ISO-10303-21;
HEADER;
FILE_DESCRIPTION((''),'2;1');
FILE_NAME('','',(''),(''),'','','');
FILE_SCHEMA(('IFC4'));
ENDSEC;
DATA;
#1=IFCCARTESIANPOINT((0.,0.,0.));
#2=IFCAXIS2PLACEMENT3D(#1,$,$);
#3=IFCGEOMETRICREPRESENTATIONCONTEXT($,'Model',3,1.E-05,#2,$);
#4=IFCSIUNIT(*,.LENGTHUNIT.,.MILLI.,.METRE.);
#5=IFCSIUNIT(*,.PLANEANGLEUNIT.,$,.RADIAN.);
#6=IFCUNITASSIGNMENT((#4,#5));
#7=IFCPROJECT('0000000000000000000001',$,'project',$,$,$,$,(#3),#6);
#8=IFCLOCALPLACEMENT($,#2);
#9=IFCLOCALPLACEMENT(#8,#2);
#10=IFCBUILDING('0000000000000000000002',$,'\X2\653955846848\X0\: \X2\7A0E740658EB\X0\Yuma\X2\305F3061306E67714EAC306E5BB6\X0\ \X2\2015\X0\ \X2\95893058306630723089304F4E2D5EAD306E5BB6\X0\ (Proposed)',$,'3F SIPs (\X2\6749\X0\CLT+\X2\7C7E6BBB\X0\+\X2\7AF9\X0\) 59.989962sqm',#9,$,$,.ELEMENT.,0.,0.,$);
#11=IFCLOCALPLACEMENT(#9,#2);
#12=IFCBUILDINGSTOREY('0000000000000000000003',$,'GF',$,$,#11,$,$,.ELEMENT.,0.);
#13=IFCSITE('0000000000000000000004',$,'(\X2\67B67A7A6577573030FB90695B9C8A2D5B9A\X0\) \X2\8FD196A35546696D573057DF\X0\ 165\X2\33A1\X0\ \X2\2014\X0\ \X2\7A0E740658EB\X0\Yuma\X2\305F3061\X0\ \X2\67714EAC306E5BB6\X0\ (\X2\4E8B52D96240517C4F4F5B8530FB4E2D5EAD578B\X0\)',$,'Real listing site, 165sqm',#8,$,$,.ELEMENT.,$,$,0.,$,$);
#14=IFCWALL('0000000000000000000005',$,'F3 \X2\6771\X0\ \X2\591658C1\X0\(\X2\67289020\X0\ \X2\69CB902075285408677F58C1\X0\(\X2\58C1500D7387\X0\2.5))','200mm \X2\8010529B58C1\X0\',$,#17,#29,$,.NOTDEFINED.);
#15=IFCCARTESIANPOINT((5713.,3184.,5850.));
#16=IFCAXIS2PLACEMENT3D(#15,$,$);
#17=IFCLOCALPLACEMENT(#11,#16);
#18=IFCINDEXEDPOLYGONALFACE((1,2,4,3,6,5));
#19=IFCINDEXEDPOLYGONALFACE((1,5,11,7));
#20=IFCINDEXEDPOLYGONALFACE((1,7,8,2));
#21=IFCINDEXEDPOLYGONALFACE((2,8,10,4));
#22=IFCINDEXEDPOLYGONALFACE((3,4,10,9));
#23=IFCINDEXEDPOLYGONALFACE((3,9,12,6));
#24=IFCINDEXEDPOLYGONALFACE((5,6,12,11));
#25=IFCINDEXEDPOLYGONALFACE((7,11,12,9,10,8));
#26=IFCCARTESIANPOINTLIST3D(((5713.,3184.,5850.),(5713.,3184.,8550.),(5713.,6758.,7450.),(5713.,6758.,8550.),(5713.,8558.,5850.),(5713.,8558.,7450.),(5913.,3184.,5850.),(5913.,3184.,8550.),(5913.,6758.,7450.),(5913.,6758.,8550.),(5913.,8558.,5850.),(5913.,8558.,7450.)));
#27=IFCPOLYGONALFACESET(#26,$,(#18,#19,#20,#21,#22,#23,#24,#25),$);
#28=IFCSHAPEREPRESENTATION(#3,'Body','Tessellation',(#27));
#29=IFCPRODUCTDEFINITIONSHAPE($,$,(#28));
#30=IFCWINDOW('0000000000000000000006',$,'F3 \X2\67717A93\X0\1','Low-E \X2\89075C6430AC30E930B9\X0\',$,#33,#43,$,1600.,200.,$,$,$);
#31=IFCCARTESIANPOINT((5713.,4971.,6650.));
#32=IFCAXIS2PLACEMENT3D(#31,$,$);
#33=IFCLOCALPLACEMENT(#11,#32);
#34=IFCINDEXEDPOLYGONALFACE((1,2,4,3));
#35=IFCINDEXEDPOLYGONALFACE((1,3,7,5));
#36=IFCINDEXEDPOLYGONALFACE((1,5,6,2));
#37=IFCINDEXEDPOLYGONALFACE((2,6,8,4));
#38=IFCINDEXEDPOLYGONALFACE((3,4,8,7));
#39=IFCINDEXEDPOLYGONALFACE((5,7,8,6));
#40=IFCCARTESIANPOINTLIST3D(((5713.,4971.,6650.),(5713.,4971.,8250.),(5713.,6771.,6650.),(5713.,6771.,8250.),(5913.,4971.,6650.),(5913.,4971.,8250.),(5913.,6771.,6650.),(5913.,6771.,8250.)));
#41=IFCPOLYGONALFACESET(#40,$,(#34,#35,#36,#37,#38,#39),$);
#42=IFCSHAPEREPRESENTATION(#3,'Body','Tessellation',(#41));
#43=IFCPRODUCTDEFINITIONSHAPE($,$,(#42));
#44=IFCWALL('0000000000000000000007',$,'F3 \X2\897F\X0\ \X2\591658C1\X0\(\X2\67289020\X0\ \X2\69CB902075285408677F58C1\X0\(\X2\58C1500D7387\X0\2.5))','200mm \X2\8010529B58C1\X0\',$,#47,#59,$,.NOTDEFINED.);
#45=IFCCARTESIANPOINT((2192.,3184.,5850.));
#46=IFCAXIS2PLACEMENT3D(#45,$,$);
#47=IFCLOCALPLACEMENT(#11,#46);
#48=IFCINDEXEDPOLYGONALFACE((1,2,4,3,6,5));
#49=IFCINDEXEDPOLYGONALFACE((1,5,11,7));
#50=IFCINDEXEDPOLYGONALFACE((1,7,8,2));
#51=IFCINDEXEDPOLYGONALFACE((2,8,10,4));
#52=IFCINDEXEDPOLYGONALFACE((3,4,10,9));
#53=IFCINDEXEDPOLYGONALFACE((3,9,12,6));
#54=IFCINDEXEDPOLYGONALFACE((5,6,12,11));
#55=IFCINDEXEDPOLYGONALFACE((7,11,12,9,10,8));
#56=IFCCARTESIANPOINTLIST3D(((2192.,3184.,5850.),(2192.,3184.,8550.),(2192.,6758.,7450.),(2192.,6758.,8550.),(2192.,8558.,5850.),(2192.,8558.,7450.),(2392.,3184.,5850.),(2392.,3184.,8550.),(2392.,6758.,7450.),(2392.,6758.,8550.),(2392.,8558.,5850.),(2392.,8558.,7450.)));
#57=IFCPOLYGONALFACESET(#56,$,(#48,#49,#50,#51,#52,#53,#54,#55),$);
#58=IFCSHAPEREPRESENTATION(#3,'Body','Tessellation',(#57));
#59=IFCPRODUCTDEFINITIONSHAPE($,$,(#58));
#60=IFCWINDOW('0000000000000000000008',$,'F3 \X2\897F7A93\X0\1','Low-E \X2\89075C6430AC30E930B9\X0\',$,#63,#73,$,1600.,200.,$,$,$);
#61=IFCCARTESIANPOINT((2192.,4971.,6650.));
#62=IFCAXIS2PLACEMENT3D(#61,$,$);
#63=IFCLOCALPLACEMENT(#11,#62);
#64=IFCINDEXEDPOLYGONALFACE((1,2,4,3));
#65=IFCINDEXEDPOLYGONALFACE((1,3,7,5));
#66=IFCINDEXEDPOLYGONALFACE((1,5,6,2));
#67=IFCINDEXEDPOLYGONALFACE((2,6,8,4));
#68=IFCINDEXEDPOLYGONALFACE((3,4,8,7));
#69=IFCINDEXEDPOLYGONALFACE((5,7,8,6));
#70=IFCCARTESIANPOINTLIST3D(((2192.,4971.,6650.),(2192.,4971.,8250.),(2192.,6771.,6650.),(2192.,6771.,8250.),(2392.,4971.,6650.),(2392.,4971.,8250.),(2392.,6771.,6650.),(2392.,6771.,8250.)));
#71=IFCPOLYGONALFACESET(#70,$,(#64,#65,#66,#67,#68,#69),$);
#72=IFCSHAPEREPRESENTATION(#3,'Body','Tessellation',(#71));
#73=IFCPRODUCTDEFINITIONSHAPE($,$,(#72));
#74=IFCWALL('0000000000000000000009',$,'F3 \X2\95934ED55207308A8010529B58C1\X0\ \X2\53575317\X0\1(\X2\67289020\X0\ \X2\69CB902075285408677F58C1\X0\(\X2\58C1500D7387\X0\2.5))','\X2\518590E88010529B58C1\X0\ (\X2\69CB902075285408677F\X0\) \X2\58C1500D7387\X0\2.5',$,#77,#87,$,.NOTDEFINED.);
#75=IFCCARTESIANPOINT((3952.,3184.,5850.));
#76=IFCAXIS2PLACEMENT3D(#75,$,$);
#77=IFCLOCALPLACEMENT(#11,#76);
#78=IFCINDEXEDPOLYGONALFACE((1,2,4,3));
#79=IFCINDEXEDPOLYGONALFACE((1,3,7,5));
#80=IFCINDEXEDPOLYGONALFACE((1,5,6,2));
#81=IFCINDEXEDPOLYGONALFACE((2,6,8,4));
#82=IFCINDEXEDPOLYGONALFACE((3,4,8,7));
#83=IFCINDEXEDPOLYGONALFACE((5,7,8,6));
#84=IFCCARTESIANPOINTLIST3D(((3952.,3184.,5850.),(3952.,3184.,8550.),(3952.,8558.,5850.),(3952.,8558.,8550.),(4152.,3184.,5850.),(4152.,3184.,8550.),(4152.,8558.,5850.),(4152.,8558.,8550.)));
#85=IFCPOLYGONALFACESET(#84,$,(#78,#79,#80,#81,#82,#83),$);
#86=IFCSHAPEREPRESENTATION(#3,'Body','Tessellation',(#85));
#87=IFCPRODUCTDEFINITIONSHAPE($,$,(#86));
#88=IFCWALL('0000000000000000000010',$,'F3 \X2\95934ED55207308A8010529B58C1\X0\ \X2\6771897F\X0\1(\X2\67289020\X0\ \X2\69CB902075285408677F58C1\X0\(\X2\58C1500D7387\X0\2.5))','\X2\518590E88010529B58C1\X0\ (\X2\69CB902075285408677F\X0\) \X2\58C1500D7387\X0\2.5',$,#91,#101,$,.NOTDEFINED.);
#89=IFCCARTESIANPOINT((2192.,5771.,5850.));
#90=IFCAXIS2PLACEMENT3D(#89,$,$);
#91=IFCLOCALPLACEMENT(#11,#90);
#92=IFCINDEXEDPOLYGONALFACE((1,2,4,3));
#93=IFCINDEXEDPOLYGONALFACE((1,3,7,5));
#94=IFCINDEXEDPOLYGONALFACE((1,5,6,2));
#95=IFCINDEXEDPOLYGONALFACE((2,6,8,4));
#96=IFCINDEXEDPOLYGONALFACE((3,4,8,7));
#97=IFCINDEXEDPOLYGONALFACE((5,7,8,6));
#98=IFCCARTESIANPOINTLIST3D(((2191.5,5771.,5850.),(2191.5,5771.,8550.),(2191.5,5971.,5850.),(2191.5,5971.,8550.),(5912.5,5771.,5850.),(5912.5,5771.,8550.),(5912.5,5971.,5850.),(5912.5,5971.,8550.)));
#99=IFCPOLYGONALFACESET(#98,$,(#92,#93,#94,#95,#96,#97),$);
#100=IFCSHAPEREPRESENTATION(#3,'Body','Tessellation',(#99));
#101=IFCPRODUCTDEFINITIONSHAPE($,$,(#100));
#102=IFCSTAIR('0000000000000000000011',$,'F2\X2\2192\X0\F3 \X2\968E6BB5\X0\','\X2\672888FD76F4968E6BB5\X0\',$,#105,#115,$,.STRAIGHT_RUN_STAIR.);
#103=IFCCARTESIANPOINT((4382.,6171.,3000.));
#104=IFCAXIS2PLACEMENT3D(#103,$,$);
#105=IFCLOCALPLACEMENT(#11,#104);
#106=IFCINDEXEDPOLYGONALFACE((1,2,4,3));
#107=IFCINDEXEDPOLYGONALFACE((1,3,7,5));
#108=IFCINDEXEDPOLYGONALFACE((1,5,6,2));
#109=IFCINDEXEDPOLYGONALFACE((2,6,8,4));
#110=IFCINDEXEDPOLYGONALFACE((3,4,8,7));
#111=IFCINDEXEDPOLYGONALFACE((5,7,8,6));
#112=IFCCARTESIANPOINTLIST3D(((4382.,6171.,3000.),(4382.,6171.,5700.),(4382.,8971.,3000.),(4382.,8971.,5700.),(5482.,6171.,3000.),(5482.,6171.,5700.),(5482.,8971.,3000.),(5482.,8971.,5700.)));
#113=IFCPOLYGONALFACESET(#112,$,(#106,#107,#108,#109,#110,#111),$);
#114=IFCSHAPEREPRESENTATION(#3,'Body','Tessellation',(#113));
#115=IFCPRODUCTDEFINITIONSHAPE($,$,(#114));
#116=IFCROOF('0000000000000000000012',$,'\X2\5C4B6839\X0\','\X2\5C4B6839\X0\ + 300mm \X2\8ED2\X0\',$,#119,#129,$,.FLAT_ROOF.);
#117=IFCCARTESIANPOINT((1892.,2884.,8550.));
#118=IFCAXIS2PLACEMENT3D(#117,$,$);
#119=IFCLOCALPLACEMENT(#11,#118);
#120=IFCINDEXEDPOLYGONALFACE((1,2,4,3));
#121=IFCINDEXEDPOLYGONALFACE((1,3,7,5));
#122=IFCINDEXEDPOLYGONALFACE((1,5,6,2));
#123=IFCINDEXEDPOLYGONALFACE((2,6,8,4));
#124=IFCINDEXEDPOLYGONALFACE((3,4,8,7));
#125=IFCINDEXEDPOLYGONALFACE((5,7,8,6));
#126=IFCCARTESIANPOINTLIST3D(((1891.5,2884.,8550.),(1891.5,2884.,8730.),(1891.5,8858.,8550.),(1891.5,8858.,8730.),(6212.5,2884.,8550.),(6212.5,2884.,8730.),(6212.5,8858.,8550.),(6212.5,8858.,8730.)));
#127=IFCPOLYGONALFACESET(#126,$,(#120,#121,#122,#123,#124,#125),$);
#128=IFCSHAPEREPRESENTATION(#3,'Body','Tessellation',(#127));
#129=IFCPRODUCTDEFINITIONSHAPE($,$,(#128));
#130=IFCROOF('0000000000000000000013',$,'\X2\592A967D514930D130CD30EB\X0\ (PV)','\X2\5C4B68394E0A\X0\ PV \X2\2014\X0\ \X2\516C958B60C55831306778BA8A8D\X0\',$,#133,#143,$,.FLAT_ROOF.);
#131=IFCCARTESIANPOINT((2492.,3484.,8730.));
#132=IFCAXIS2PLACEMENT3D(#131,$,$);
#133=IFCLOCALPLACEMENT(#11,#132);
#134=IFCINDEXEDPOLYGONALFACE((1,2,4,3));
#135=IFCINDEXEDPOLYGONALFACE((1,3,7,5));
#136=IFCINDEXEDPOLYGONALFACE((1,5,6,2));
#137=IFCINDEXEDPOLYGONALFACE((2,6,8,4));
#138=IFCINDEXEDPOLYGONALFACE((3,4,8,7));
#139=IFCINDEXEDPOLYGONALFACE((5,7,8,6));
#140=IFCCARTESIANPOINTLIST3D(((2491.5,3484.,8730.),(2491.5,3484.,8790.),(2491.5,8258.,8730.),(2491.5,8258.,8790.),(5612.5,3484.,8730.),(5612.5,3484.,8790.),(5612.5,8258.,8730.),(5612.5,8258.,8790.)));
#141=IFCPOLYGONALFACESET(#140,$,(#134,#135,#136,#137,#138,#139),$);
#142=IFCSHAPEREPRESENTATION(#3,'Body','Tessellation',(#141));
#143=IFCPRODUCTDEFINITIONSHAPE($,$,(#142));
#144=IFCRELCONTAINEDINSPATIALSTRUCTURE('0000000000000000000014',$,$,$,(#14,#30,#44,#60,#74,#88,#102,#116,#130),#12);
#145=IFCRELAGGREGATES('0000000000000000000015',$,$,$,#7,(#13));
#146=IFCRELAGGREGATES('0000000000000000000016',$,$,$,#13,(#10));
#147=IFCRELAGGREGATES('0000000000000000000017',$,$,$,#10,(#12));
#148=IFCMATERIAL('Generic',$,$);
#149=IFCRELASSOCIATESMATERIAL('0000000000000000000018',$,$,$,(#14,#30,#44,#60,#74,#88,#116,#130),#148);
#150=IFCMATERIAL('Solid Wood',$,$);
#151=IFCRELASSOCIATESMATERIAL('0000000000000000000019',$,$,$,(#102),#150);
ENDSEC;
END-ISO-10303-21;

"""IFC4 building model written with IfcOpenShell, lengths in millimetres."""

from ifc_helpers import new_model, si_unit, frame, frame_2d, origin, place, context, project, spatial, rectangle, extrude, material, element, fill, save


model = new_model("IFC4")

# Units and contexts
model_context = context("Model", 3, precision=1e-05, world=origin())
ifc_project = project(units=[si_unit("LENGTHUNIT", "METRE", prefix="MILLI"), si_unit("PLANEANGLEUNIT", "RADIAN")], contexts=[model_context])

# Site, building, storey
site_placement = place(None, origin())
site = spatial("IfcSite", under=ifc_project, at=site_placement, Name="(架空敷地・適宜設定) 近隣商業地域 165㎡ — 税理士Yumaたち 東京の家 (事務所兼住宅・中庭型)", ObjectType="Real listing site, 165sqm", CompositionType="ELEMENT", RefElevation=0.0)
building_placement = place(site_placement, origin())
building = spatial("IfcBuilding", under=site, at=building_placement, Name="改善案: 税理士Yumaたちの東京の家 ― 閉じてひらく中庭の家 (Proposed)", ObjectType="3F SIPs (杉CLT+籾殻+竹) 59.989962sqm", CompositionType="ELEMENT", ElevationOfRefHeight=0.0, ElevationOfTerrain=0.0)
storey_placement = place(building_placement, origin())
storey = spatial("IfcBuildingStorey", under=building, at=storey_placement, Name="GF", CompositionType="ELEMENT", Elevation=0.0)

# Shared definitions
ifc_material_1 = material(Name="Generic")

# Walls, openings, windows
wall_1_placement = place(storey_placement, frame((5713.0, 3184.0, 5850.0)))
wall_1 = element("IfcWall", 1, at=wall_1_placement, inside=storey, material=ifc_material_1, Name="F3 東 外壁(木造 構造用合板壁(壁倍率2.5))", Description="200mm 耐力壁", PredefinedType="NOTDEFINED", context=model_context, shape_type="SweptSolid", body=[
    extrude(rectangle(XDim=200.0, YDim=5374.0, at=frame_2d((100.0, 2687.0))), frame((5713.0, 3184.0, 5850.0)), (0.0, 0.0, 1.0), 2700.0),
])
opening_1_placement = place(storey_placement, frame((5713.0, 4971.0, 6650.0)))
opening_1 = element("IfcOpeningElement", 2, at=opening_1_placement, cuts=wall_1, PredefinedType="NOTDEFINED", context=model_context, shape_type="SweptSolid", body=[
    extrude(rectangle(XDim=200.0, YDim=1800.0, at=frame_2d((100.0, 900.0))), frame((5713.0, 4971.0, 6650.0)), (0.0, 0.0, 1.0), 1600.0),
])
window_1_placement = place(storey_placement, frame((5713.0, 4971.0, 6650.0)))
window_1 = element("IfcWindow", 3, at=window_1_placement, inside=storey, material=ifc_material_1, Name="F3 東窓1", Description="Low-E 複層ガラス", OverallHeight=1600.0, OverallWidth=200.0, context=model_context, shape_type="SweptSolid", body=[
    extrude(rectangle(XDim=200.0, YDim=1800.0, at=frame_2d((100.0, 900.0))), frame((5713.0, 4971.0, 6650.0)), (0.0, 0.0, 1.0), 1600.0),
])
fill(opening_1, window_1)
wall_2_placement = place(storey_placement, frame((2192.0, 3184.0, 5850.0)))
wall_2 = element("IfcWall", 4, at=wall_2_placement, inside=storey, material=ifc_material_1, Name="F3 西 外壁(木造 構造用合板壁(壁倍率2.5))", Description="200mm 耐力壁", PredefinedType="NOTDEFINED", context=model_context, shape_type="SweptSolid", body=[
    extrude(rectangle(XDim=200.0, YDim=5374.0, at=frame_2d((100.0, 2687.0))), frame((2192.0, 3184.0, 5850.0)), (0.0, 0.0, 1.0), 2700.0),
])
opening_2_placement = place(storey_placement, frame((2192.0, 4971.0, 6650.0)))
opening_2 = element("IfcOpeningElement", 5, at=opening_2_placement, cuts=wall_2, PredefinedType="NOTDEFINED", context=model_context, shape_type="SweptSolid", body=[
    extrude(rectangle(XDim=200.0, YDim=1800.0, at=frame_2d((100.0, 900.0))), frame((2192.0, 4971.0, 6650.0)), (0.0, 0.0, 1.0), 1600.0),
])
window_2_placement = place(storey_placement, frame((2192.0, 4971.0, 6650.0)))
window_2 = element("IfcWindow", 6, at=window_2_placement, inside=storey, material=ifc_material_1, Name="F3 西窓1", Description="Low-E 複層ガラス", OverallHeight=1600.0, OverallWidth=200.0, context=model_context, shape_type="SweptSolid", body=[
    extrude(rectangle(XDim=200.0, YDim=1800.0, at=frame_2d((100.0, 900.0))), frame((2192.0, 4971.0, 6650.0)), (0.0, 0.0, 1.0), 1600.0),
])
fill(opening_2, window_2)

# Walls
wall_3_placement = place(storey_placement, frame((3952.0, 3184.0, 5850.0)))
element("IfcWall", 7, at=wall_3_placement, inside=storey, material=ifc_material_1, Name="F3 間仕切り耐力壁 南北1(木造 構造用合板壁(壁倍率2.5))", Description="内部耐力壁 (構造用合板) 壁倍率2.5", PredefinedType="NOTDEFINED", context=model_context, shape_type="SweptSolid", body=[
    extrude(rectangle(XDim=200.0, YDim=5374.0, at=frame_2d((100.0, 2687.0))), frame((3952.0, 3184.0, 5850.0)), (0.0, 0.0, 1.0), 2700.0),
])
wall_4_placement = place(storey_placement, frame((2192.0, 5771.0, 5850.0)))
element("IfcWall", 8, at=wall_4_placement, inside=storey, material=ifc_material_1, Name="F3 間仕切り耐力壁 東西1(木造 構造用合板壁(壁倍率2.5))", Description="内部耐力壁 (構造用合板) 壁倍率2.5", PredefinedType="NOTDEFINED", context=model_context, shape_type="SweptSolid", body=[
    extrude(rectangle(XDim=3721.0, YDim=200.0, at=frame_2d((1860.0, 100.0))), frame((2192.0, 5771.0, 5850.0)), (0.0, 0.0, 1.0), 2700.0),
])

# Stair
ifc_material_2 = material(Name="Solid Wood")
stair_placement = place(storey_placement, frame((4382.0, 6171.0, 3000.0)))
element("IfcStair", 9, at=stair_placement, inside=storey, material=ifc_material_2, Name="F2→F3 階段", Description="木製直階段", PredefinedType="STRAIGHT_RUN_STAIR", context=model_context, shape_type="SweptSolid", body=[
    extrude(rectangle(XDim=1100.0, YDim=2800.0, at=frame_2d((550.0, 1400.0))), frame((4382.0, 6171.0, 3000.0)), (0.0, 0.0, 1.0), 2700.0),
])

# Roofs
roof_1_placement = place(storey_placement, frame((1892.0, 2884.0, 8550.0)))
element("IfcRoof", 10, at=roof_1_placement, inside=storey, material=ifc_material_1, Name="屋根", Description="屋根 + 300mm 軒", PredefinedType="FLAT_ROOF", context=model_context, shape_type="SweptSolid", body=[
    extrude(rectangle(XDim=4321.0, YDim=5974.0, at=frame_2d((2160.0, 2987.0))), frame((1892.0, 2884.0, 8550.0)), (0.0, 0.0, 1.0), 180.0),
])
roof_2_placement = place(storey_placement, frame((2492.0, 3484.0, 8730.0)))
element("IfcRoof", 11, at=roof_2_placement, inside=storey, material=ifc_material_1, Name="太陽光パネル (PV)", Description="屋根上 PV — 公開情報で確認", PredefinedType="FLAT_ROOF", context=model_context, shape_type="SweptSolid", body=[
    extrude(rectangle(XDim=3121.0, YDim=4774.0, at=frame_2d((1560.0, 2387.0))), frame((2492.0, 3484.0, 8730.0)), (0.0, 0.0, 1.0), 60.0),
])

save(model, "model.ifc")
